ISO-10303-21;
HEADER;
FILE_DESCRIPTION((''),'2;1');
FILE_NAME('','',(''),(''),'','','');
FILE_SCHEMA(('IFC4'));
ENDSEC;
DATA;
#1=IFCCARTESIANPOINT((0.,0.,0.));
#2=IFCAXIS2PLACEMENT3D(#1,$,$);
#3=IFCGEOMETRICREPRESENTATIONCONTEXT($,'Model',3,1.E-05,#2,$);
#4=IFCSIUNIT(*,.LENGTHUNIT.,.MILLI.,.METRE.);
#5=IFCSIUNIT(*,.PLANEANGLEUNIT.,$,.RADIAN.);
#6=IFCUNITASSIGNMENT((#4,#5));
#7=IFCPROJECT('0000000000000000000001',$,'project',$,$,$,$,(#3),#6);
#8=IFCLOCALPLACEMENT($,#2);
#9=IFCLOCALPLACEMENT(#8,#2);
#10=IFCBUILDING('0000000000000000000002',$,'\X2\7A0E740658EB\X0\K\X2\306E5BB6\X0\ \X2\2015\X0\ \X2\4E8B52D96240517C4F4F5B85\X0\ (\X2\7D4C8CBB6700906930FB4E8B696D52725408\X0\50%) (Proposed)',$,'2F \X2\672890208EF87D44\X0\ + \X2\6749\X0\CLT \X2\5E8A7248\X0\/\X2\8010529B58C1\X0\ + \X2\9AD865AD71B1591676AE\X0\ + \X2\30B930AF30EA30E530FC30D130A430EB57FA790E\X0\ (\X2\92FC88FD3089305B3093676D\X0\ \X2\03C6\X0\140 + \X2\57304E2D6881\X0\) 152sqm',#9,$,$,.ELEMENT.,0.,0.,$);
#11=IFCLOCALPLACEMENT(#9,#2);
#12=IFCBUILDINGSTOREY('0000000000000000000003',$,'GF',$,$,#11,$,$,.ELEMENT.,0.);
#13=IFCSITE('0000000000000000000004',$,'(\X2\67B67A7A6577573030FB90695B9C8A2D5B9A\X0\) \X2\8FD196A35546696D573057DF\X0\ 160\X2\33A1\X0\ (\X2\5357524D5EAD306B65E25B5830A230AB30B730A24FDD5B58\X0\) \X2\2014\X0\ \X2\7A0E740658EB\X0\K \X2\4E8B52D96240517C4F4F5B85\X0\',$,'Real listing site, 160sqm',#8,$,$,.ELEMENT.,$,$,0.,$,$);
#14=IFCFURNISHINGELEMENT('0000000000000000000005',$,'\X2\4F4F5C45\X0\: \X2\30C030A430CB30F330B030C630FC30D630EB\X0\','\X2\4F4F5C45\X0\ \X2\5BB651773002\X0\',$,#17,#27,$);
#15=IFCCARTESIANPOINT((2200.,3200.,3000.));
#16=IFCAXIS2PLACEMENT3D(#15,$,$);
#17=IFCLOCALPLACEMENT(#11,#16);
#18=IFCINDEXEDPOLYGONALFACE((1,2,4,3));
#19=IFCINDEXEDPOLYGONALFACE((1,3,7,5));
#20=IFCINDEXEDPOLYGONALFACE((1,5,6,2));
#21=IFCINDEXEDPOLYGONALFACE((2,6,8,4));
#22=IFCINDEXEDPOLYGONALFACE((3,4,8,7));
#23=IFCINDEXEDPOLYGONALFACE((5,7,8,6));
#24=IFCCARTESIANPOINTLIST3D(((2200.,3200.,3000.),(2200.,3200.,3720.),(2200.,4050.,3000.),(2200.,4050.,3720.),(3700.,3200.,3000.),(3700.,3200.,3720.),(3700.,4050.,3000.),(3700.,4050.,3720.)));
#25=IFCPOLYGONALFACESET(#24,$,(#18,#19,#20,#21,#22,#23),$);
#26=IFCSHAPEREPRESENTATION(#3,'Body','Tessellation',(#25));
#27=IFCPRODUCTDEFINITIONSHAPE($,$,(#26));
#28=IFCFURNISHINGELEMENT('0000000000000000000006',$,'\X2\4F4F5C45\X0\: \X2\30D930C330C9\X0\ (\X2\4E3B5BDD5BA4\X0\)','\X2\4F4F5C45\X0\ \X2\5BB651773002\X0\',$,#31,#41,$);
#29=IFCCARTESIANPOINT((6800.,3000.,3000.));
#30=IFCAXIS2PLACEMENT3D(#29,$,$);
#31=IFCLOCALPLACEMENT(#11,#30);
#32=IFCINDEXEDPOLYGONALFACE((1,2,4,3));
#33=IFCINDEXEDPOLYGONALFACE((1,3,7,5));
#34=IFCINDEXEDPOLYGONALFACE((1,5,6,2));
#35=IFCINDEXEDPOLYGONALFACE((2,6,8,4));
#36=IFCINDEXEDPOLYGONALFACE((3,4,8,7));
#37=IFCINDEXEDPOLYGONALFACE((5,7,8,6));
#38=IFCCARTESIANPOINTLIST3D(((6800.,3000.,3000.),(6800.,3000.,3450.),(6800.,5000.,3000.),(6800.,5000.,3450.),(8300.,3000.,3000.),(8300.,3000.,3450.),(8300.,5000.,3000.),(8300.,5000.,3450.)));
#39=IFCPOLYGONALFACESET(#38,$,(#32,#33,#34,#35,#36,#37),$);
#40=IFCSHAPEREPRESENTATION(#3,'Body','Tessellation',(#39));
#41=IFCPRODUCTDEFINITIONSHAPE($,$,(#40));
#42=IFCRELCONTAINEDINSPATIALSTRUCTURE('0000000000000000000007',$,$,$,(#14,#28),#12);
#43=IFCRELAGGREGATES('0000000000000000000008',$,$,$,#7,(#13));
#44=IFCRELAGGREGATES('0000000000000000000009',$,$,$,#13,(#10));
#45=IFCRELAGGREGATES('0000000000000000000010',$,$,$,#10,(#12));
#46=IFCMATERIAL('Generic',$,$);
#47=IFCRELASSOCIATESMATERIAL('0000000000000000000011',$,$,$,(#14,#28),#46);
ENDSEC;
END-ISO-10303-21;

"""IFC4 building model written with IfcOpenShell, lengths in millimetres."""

from ifc_helpers import new_model, si_unit, frame, frame_2d, origin, place, context, project, spatial, rectangle, extrude, material, element, save


model = new_model("IFC4")

# Units and contexts
model_context = context("Model", 3, precision=1e-05, world=origin())
ifc_project = project(units=[si_unit("LENGTHUNIT", "METRE", prefix="MILLI"), si_unit("PLANEANGLEUNIT", "RADIAN")], contexts=[model_context])

# Site, building, storey
site_placement = place(None, origin())
site = spatial("IfcSite", under=ifc_project, at=site_placement, Name="(架空敷地・適宜設定) 近隣商業地域 160㎡ (南前庭に既存アカシア保存) — 税理士K 事務所兼住宅", ObjectType="Real listing site, 160sqm", CompositionType="ELEMENT", RefElevation=0.0)
building_placement = place(site_placement, origin())
building = spatial("IfcBuilding", under=site, at=building_placement, Name="税理士Kの家 ― 事務所兼住宅 (経費最適・事業割合50%) (Proposed)", ObjectType="2F 木造軸組 + 杉CLT 床版/耐力壁 + 高断熱外皮 + スクリューパイル基礎 (鋼製らせん杭 φ140 + 地中梁) 152sqm", CompositionType="ELEMENT", ElevationOfRefHeight=0.0, ElevationOfTerrain=0.0)
storey_placement = place(building_placement, origin())
storey = spatial("IfcBuildingStorey", under=building, at=storey_placement, Name="GF", CompositionType="ELEMENT", Elevation=0.0)

# Shared definitions
ifc_material = material(Name="Generic")

# Furnishing elements
furnishing_1_placement = place(storey_placement, frame((2200.0, 3200.0, 3000.0)))
element("IfcFurnishingElement", 1, at=furnishing_1_placement, inside=storey, material=ifc_material, Name="住居: ダイニングテーブル", Description="住居 家具。", context=model_context, shape_type="SweptSolid", body=[
    extrude(rectangle(XDim=1500.0, YDim=850.0, at=frame_2d((750.0, 425.0))), frame((2200.0, 3200.0, 3000.0)), (0.0, 0.0, 1.0), 720.0),
])
furnishing_2_placement = place(storey_placement, frame((6800.0, 3000.0, 3000.0)))
element("IfcFurnishingElement", 2, at=furnishing_2_placement, inside=storey, material=ifc_material, Name="住居: ベッド (主寝室)", Description="住居 家具。", context=model_context, shape_type="SweptSolid", body=[
    extrude(rectangle(XDim=1500.0, YDim=2000.0, at=frame_2d((750.0, 1000.0))), frame((6800.0, 3000.0, 3000.0)), (0.0, 0.0, 1.0), 450.0),
])

save(model, "model.ifc")
